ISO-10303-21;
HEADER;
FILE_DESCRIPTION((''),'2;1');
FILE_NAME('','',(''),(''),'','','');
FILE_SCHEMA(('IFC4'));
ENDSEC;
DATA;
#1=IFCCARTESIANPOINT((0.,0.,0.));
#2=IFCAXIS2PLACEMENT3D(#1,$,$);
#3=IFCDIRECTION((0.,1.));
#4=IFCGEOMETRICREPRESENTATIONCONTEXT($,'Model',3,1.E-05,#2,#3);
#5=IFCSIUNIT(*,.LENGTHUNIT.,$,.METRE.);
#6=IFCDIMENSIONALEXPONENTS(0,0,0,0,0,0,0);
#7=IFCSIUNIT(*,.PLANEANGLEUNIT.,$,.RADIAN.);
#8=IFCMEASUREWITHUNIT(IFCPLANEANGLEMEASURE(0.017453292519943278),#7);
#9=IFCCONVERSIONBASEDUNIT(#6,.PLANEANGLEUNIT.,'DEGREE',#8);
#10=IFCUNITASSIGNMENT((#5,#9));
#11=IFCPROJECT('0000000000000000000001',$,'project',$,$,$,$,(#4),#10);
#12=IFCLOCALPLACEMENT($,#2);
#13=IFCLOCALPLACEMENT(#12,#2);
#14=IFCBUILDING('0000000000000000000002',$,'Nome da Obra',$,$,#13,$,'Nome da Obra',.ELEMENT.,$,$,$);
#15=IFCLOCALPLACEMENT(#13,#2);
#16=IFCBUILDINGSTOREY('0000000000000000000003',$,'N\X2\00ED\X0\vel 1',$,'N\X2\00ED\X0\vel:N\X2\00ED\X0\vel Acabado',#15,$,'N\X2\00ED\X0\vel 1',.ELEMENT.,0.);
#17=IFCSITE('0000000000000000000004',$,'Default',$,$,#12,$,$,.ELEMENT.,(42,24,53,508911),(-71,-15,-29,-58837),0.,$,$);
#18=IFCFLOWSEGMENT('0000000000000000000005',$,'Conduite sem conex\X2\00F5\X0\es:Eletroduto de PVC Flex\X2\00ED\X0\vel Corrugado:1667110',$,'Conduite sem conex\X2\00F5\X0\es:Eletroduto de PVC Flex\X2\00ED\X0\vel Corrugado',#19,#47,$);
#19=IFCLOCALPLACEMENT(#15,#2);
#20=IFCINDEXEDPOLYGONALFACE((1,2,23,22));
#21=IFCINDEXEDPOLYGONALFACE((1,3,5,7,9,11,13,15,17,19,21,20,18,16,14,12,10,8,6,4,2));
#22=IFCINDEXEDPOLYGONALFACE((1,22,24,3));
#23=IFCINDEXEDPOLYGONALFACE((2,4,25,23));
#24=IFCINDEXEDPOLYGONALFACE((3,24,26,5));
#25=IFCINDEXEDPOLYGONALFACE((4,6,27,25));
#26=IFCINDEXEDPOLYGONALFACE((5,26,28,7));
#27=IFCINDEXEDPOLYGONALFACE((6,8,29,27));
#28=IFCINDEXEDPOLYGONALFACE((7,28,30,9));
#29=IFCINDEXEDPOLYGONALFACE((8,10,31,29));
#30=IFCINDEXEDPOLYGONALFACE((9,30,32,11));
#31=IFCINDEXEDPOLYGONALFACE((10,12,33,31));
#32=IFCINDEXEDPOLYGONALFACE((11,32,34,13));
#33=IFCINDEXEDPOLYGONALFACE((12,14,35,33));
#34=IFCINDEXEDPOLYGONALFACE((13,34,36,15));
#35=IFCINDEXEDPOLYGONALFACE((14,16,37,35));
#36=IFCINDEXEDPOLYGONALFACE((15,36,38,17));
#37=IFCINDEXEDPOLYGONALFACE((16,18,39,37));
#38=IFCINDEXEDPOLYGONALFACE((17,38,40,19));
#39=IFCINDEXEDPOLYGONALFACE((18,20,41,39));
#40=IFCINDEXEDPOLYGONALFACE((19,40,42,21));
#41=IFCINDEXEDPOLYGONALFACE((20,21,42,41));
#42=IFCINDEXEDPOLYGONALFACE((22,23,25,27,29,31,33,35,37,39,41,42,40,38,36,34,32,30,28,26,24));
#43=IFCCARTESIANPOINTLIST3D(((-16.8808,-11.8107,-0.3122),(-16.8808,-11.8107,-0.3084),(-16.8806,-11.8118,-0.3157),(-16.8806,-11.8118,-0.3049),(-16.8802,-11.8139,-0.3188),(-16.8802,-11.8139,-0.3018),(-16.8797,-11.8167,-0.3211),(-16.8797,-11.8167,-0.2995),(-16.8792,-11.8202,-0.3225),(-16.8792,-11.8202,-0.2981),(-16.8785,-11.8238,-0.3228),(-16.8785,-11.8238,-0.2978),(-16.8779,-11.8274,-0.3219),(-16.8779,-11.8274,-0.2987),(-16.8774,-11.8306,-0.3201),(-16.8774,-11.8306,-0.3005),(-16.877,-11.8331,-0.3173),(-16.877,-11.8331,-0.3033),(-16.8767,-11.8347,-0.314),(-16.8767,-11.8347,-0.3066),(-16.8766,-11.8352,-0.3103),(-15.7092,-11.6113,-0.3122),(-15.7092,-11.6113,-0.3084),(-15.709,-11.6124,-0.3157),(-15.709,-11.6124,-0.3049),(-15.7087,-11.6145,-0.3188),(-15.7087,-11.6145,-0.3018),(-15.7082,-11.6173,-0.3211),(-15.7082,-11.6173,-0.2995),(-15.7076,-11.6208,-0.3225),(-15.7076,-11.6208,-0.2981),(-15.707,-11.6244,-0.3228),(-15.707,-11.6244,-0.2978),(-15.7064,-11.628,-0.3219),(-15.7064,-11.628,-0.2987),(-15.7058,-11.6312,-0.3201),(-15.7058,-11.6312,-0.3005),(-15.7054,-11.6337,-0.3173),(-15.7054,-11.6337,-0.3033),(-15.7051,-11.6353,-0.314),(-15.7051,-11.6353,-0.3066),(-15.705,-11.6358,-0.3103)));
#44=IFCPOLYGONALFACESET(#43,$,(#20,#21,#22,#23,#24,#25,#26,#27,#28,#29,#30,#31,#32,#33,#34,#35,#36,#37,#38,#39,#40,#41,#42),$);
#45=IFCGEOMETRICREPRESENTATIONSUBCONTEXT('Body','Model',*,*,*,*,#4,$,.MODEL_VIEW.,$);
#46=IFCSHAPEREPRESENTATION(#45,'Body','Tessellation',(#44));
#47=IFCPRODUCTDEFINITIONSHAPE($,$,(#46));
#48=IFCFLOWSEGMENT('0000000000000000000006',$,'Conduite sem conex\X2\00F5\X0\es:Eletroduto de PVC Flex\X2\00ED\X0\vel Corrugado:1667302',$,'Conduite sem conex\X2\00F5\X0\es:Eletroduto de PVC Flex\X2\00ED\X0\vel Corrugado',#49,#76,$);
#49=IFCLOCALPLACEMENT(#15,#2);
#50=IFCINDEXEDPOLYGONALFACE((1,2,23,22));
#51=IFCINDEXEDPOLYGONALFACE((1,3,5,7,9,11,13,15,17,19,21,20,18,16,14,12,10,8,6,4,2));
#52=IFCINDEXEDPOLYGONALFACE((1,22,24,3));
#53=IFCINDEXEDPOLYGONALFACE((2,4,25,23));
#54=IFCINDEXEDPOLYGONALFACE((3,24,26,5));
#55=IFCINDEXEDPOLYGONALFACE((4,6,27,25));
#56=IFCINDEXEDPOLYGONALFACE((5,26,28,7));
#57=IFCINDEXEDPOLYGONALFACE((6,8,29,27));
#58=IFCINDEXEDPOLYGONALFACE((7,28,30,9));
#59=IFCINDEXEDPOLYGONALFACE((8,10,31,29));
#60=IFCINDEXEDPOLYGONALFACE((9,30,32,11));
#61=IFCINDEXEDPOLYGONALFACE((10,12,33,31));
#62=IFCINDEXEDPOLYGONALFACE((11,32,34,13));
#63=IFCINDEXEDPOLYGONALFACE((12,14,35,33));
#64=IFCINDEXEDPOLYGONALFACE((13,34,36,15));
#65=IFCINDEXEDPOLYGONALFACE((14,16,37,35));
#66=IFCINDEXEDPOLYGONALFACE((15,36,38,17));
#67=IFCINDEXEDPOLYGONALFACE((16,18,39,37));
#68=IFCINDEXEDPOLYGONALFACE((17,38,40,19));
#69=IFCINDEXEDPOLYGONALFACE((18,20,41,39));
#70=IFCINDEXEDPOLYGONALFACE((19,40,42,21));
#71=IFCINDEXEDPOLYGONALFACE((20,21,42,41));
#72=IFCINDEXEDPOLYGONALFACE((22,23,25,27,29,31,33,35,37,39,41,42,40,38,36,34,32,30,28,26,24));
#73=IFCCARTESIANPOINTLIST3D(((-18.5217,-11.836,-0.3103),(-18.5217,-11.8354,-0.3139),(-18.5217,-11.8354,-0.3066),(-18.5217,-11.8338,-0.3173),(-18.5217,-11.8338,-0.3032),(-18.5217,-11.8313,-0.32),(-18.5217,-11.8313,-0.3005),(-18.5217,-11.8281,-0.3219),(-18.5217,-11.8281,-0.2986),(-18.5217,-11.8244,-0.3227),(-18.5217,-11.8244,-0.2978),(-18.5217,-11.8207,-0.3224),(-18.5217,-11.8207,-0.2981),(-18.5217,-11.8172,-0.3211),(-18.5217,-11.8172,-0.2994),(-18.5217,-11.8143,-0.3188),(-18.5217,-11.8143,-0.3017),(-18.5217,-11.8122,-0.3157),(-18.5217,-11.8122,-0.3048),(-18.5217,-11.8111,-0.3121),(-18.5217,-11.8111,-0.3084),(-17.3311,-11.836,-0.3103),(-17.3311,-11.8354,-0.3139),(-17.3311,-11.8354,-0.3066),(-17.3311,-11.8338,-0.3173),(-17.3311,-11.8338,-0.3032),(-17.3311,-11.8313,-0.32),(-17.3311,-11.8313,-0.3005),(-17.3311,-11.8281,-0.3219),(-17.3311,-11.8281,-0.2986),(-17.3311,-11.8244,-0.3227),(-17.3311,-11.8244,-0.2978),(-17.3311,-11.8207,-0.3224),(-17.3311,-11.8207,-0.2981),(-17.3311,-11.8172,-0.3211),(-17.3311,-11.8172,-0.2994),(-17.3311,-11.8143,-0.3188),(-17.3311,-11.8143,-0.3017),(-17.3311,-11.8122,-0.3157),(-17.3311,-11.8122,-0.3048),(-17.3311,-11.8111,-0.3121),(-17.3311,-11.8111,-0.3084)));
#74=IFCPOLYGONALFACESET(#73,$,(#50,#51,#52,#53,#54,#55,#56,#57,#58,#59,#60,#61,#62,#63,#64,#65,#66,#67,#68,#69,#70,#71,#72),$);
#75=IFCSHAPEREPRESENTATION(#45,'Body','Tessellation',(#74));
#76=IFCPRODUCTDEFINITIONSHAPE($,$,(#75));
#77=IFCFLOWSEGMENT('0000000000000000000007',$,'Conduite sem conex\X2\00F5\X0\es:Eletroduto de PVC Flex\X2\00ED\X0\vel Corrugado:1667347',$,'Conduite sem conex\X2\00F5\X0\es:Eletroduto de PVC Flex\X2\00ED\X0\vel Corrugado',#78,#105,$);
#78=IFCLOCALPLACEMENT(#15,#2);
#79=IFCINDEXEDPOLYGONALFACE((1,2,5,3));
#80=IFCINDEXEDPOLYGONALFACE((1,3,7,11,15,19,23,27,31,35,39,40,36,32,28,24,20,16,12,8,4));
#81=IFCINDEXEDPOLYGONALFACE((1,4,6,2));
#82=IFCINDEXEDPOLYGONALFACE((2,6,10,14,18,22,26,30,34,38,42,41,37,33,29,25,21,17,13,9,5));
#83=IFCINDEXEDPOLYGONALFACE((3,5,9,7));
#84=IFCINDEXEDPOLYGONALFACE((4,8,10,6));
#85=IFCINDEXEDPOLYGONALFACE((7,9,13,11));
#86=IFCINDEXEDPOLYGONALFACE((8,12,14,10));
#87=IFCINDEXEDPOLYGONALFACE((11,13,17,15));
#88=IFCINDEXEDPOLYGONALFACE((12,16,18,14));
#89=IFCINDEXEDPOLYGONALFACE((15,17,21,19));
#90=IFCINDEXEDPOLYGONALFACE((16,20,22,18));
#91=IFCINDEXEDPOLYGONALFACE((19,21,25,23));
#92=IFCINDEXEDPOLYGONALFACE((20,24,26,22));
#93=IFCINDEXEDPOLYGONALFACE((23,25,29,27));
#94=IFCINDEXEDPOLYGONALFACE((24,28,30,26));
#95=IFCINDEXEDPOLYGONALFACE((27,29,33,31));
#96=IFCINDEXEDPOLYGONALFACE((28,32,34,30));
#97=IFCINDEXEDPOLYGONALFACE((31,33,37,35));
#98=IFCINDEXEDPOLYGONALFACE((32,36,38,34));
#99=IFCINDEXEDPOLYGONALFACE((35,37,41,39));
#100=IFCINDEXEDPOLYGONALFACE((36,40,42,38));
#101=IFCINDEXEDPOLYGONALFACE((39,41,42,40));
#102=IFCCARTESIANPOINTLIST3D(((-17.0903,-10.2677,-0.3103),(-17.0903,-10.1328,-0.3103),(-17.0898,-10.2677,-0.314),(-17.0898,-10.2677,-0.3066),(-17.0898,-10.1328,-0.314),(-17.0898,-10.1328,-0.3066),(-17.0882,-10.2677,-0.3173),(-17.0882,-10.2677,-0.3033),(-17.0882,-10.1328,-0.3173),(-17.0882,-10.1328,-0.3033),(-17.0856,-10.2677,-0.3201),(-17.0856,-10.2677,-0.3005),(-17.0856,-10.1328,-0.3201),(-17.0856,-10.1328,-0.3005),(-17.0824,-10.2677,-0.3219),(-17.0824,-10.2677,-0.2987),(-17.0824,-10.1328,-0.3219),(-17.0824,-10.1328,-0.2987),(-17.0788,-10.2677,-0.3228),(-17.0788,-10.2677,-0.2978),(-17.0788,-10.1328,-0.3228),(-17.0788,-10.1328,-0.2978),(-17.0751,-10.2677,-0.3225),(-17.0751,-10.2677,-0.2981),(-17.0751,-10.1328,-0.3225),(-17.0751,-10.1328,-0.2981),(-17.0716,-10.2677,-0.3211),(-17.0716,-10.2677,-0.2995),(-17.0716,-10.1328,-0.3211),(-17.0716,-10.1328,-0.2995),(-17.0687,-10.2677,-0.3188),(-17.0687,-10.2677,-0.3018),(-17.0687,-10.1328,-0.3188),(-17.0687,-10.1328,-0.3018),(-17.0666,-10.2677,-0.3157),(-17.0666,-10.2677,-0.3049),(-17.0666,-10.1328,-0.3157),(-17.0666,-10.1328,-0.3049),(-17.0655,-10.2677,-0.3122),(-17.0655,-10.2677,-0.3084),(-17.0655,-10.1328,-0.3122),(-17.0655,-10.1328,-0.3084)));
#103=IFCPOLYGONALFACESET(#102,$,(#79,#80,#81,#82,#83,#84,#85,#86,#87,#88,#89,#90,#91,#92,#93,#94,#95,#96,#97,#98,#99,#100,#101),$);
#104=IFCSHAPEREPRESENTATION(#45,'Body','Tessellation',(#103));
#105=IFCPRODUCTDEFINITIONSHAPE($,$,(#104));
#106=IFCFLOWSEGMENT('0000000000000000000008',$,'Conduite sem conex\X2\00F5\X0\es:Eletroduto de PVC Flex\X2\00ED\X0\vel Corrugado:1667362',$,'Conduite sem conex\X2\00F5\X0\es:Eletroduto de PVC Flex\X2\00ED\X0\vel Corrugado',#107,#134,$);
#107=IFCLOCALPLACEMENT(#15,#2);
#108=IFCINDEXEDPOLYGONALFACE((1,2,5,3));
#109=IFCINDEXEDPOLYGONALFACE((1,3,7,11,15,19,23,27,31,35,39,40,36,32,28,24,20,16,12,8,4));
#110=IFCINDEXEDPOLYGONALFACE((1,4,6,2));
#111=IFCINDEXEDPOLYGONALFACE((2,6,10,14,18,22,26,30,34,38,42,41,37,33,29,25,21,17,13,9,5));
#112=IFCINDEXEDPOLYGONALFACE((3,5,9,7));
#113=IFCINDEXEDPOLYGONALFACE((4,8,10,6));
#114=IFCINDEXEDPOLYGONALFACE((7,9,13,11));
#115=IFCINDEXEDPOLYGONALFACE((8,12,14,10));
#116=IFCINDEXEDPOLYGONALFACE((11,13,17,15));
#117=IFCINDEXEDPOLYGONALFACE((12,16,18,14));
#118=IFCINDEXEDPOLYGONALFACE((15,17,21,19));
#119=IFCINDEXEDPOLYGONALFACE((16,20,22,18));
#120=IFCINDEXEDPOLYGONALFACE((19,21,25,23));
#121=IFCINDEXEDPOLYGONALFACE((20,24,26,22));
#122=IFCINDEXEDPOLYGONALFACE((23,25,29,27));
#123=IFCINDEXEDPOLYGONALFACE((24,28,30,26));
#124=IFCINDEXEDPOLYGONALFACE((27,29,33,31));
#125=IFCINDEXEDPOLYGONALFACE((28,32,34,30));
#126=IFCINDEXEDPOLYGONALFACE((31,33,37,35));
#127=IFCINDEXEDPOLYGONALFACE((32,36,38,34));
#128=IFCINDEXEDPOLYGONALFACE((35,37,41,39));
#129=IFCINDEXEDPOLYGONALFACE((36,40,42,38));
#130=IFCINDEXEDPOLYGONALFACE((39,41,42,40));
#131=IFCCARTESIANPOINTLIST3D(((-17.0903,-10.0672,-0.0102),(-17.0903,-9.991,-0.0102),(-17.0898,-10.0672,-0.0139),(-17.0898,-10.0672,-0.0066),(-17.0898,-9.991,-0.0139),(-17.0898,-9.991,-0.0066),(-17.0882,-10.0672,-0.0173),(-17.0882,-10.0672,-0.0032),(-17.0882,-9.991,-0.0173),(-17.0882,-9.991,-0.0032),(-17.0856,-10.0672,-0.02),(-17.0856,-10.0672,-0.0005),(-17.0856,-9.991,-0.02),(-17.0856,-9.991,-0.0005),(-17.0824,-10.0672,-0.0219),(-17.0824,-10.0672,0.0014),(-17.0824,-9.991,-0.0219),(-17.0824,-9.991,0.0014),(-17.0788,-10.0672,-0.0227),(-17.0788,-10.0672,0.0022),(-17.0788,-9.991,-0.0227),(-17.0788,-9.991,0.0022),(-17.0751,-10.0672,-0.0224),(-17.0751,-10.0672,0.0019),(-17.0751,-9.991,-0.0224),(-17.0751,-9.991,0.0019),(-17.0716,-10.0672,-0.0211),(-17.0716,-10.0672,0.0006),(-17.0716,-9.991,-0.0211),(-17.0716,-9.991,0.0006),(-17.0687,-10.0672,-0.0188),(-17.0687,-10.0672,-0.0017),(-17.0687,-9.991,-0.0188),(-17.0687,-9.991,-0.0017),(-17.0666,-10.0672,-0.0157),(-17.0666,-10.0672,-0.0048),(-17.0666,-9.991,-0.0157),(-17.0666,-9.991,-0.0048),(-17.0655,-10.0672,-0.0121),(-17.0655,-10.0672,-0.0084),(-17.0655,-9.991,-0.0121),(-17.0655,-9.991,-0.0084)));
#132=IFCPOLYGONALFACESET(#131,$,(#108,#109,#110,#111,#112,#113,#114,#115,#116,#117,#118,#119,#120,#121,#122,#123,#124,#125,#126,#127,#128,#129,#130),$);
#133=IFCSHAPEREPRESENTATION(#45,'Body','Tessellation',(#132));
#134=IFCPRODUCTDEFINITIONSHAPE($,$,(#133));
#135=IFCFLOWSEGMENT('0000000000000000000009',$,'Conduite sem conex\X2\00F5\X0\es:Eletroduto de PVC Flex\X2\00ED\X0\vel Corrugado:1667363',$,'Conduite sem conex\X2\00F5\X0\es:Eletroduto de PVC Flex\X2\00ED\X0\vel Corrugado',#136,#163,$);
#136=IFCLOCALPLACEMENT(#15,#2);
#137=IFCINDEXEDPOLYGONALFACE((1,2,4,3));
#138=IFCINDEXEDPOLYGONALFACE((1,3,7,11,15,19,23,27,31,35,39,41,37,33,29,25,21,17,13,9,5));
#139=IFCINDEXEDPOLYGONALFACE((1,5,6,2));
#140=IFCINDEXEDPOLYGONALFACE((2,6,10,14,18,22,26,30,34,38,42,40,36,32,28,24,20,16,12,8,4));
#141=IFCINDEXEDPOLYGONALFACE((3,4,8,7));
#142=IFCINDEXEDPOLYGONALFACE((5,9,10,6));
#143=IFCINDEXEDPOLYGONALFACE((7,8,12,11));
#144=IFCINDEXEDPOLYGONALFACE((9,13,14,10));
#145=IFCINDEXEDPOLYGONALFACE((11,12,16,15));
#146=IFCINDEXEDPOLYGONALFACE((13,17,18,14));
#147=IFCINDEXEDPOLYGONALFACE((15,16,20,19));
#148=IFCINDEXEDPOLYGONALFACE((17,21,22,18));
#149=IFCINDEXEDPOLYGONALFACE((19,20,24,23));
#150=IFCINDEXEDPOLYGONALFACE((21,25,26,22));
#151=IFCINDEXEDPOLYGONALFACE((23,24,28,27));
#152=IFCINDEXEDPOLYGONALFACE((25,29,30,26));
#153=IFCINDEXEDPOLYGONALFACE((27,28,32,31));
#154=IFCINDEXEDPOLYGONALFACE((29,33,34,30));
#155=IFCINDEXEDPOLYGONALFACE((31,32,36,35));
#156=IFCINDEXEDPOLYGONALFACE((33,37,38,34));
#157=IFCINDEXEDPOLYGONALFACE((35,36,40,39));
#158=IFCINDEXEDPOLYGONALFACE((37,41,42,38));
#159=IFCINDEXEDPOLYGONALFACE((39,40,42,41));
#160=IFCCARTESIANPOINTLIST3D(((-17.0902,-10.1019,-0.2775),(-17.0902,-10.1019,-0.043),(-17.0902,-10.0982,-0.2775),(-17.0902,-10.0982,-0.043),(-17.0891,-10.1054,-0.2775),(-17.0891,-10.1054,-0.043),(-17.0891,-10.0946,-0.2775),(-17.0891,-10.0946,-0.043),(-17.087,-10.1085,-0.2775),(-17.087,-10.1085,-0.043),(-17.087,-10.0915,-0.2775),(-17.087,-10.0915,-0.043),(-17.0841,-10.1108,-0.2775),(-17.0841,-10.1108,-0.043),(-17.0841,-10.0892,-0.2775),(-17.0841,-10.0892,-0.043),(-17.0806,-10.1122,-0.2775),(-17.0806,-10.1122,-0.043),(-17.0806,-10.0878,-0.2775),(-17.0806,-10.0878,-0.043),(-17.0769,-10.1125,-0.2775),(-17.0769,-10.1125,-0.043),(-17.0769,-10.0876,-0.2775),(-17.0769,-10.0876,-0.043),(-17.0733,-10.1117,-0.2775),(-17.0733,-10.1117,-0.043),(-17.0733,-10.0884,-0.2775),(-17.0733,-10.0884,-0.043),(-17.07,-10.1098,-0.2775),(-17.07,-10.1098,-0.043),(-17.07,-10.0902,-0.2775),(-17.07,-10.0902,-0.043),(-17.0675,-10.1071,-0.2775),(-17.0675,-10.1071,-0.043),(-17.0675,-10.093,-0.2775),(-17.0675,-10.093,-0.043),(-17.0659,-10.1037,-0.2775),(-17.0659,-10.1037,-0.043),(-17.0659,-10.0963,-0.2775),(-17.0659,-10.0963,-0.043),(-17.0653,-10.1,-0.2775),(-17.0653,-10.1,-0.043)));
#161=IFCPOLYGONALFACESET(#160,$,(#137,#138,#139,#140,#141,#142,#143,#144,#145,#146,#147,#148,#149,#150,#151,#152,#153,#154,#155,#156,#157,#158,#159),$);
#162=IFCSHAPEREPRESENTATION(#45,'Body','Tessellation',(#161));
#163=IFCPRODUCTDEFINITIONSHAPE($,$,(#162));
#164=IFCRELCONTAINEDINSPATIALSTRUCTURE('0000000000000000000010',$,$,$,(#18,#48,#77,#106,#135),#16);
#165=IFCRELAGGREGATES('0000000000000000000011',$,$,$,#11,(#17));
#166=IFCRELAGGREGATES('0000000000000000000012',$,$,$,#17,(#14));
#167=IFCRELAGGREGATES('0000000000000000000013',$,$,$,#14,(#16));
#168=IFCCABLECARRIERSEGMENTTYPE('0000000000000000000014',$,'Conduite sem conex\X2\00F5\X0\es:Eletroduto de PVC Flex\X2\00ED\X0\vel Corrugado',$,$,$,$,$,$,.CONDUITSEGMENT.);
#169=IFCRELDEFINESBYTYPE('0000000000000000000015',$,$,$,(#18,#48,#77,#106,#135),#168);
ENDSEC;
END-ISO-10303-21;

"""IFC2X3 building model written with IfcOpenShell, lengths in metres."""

from ifc_helpers import new_model, entity, si_unit, converted_unit, direction, frame, frame_2d, origin, origin_2d_with_axis, place, context, subcontext, project, spatial, circle, extrude, type_object, element, save


model = new_model("IFC2X3")

# Units and contexts
model_context = context("Model", 3, precision=1e-05, world=origin(), true_north=direction((0.0, 1.0)))
body_context = subcontext(model_context, "Body", "Model", "MODEL_VIEW")
ifc_project = project(units=[si_unit("LENGTHUNIT", "METRE"), converted_unit("PLANEANGLEUNIT", "DEGREE", entity("IfcPlaneAngleMeasure", 0.017453292519943278), si_unit("PLANEANGLEUNIT", "RADIAN"), dimensions=[0, 0, 0, 0, 0, 0, 0])], contexts=[model_context])

# Site, building, storey
site_placement = place(None, origin())
site = spatial("IfcSite", under=ifc_project, at=site_placement, Name="Default", CompositionType="ELEMENT", RefLatitude=(42, 24, 53, 508911), RefLongitude=(-71, -15, -29, -58837), RefElevation=0.0)
building_placement = place(site_placement, origin())
building = spatial("IfcBuilding", under=site, at=building_placement, Name="Nome da Obra", LongName="Nome da Obra", CompositionType="ELEMENT")
storey_placement = place(building_placement, origin())
storey = spatial("IfcBuildingStorey", under=building, at=storey_placement, Name="Nível 1", ObjectType="Nível:Nível Acabado", LongName="Nível 1", CompositionType="ELEMENT", Elevation=0.0)

# Flow segments
cable_carrier_segment_type = type_object("IfcCableCarrierSegmentType", Name="Conduite sem conexões:Eletroduto de PVC Flexível Corrugado", PredefinedType="CONDUITSEGMENT")
flow_segment_1_placement = place(storey_placement, origin())
element("IfcFlowSegment", 1, at=flow_segment_1_placement, inside=storey, type_object=cable_carrier_segment_type, Name="Conduite sem conexões:Eletroduto de PVC Flexível Corrugado:1667110", ObjectType="Conduite sem conexões:Eletroduto de PVC Flexível Corrugado", context=body_context, shape_type="SweptSolid", body=[
    extrude(circle(Radius=0.0125, at=frame_2d((0.0, 0.0), x_axis=(1.0, 0.0))), frame((-16.8787, -11.8229, -0.3103), z_axis=(0.985823, 0.167788, 0.0), x_axis=(0.167788, -0.985823, 0.000247)), (0.0, 0.0, 1.0), 1.1884),
])
flow_segment_2_placement = place(storey_placement, origin())
element("IfcFlowSegment", 2, at=flow_segment_2_placement, inside=storey, type_object=cable_carrier_segment_type, Name="Conduite sem conexões:Eletroduto de PVC Flexível Corrugado:1667302", ObjectType="Conduite sem conexões:Eletroduto de PVC Flexível Corrugado", context=body_context, shape_type="SweptSolid", body=[
    extrude(circle(Radius=0.0125, at=origin_2d_with_axis()), frame((-18.5217, -11.8235, -0.3103), z_axis=(1.0, 0.0, 0.0), x_axis=(0.0, -1.0, 0.0)), (0.0, 0.0, 1.0), 1.1905),
])
flow_segment_3_placement = place(storey_placement, origin())
element("IfcFlowSegment", 3, at=flow_segment_3_placement, inside=storey, type_object=cable_carrier_segment_type, Name="Conduite sem conexões:Eletroduto de PVC Flexível Corrugado:1667347", ObjectType="Conduite sem conexões:Eletroduto de PVC Flexível Corrugado", context=body_context, shape_type="SweptSolid", body=[
    extrude(circle(Radius=0.0125, at=frame_2d((0.0, 0.0), x_axis=(1.0, 0.0))), frame((-17.0778, -10.2677, -0.3103), z_axis=(0.0, 1.0, 0.0), x_axis=(-1.0, 0.0, 0.0)), (0.0, 0.0, 1.0), 0.1349),
])
flow_segment_4_placement = place(storey_placement, origin())
element("IfcFlowSegment", 4, at=flow_segment_4_placement, inside=storey, type_object=cable_carrier_segment_type, Name="Conduite sem conexões:Eletroduto de PVC Flexível Corrugado:1667362", ObjectType="Conduite sem conexões:Eletroduto de PVC Flexível Corrugado", context=body_context, shape_type="SweptSolid", body=[
    extrude(circle(Radius=0.0125, at=frame_2d((0.0, 0.0), x_axis=(1.0, 0.0))), frame((-17.0778, -10.0672, -0.0102), z_axis=(0.0, 1.0, 0.0), x_axis=(-1.0, 0.0, 0.0)), (0.0, 0.0, 1.0), 0.0762),
])
flow_segment_5_placement = place(storey_placement, origin())
element("IfcFlowSegment", 5, at=flow_segment_5_placement, inside=storey, type_object=cable_carrier_segment_type, Name="Conduite sem conexões:Eletroduto de PVC Flexível Corrugado:1667363", ObjectType="Conduite sem conexões:Eletroduto de PVC Flexível Corrugado", context=body_context, shape_type="SweptSolid", body=[
    extrude(circle(Radius=0.0125, at=frame_2d((0.0, 0.0), x_axis=(1.0, 0.0))), frame((-17.0778, -10.1, -0.2775)), (0.0, 0.0, 1.0), 0.2345),
])

save(model, "model.ifc")
